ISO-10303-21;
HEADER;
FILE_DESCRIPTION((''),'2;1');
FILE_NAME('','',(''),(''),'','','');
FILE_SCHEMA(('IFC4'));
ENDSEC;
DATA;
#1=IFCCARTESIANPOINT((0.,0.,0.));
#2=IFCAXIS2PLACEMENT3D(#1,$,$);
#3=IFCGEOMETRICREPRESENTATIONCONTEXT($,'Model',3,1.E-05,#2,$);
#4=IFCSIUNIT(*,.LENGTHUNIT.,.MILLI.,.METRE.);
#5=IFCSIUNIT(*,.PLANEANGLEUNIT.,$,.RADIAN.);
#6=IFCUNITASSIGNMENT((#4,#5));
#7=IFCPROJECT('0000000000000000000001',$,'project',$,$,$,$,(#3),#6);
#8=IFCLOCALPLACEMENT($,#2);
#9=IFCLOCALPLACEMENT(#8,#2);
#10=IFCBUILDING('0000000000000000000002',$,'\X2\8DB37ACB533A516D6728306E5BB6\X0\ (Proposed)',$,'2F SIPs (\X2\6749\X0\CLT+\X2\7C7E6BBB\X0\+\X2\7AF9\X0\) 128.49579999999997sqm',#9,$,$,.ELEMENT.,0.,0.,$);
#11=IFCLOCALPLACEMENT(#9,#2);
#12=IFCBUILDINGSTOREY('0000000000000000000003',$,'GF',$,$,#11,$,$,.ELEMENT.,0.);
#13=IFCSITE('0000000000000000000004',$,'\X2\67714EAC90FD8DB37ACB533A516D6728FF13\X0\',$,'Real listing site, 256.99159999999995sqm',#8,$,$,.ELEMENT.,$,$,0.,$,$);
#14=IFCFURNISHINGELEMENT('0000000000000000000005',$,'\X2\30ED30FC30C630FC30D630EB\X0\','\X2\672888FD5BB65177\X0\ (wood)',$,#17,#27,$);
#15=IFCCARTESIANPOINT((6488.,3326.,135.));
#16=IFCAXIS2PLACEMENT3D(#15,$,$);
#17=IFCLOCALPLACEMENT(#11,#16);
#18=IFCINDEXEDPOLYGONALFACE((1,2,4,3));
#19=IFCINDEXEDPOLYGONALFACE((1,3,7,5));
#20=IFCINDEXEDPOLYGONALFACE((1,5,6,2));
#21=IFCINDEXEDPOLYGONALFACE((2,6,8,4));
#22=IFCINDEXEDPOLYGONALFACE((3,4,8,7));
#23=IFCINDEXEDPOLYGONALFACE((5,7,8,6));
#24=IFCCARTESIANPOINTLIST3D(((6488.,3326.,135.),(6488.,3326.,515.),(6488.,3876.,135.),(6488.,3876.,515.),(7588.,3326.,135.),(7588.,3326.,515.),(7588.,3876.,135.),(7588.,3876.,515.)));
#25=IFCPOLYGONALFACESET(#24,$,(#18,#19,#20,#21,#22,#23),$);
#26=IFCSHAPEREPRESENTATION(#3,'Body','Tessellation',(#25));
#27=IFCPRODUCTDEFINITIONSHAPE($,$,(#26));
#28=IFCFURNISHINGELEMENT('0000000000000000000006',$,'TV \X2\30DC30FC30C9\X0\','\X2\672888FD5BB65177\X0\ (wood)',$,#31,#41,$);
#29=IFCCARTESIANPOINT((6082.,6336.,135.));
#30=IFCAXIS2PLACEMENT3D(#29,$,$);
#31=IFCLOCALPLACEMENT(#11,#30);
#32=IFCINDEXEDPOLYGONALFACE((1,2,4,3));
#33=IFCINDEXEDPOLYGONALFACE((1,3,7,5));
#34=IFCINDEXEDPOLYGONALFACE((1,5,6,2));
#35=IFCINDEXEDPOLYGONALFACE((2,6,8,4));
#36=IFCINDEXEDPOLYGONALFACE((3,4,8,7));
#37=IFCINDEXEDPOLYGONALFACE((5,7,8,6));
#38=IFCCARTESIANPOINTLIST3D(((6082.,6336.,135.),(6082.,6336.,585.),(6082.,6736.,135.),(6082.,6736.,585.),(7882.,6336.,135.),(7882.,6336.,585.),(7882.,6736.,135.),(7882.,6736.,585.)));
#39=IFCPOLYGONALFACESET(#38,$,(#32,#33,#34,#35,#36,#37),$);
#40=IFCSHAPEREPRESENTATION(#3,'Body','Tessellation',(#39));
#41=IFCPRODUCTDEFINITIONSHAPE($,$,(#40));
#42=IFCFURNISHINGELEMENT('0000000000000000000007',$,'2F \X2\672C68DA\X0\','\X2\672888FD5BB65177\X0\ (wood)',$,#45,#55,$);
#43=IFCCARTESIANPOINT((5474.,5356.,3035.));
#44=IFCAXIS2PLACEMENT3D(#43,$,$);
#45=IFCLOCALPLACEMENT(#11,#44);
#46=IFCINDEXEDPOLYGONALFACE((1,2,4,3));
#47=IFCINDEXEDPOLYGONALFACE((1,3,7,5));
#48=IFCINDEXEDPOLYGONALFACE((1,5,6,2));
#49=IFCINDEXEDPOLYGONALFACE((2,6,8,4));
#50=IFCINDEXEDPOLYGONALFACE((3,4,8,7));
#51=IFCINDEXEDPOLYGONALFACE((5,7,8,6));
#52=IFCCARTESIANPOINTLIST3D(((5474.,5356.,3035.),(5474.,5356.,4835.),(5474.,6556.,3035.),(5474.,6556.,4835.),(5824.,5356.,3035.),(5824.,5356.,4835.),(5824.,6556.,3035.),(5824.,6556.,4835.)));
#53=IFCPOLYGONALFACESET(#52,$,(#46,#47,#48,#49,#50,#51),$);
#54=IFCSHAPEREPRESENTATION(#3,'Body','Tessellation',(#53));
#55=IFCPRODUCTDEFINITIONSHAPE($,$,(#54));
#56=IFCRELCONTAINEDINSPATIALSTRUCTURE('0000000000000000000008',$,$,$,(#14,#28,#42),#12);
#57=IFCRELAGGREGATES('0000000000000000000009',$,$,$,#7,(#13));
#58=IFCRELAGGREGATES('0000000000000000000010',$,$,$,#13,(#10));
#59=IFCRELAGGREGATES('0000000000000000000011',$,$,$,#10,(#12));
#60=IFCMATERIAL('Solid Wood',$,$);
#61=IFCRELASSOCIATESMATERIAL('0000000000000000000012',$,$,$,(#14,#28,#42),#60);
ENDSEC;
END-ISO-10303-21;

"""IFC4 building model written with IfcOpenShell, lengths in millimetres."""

from ifc_helpers import new_model, si_unit, frame, frame_2d, origin, place, context, project, spatial, rectangle, extrude, material, element, save


model = new_model("IFC4")

# Units and contexts
model_context = context("Model", 3, precision=1e-05, world=origin())
ifc_project = project(units=[si_unit("LENGTHUNIT", "METRE", prefix="MILLI"), si_unit("PLANEANGLEUNIT", "RADIAN")], contexts=[model_context])

# Site, building, storey
site_placement = place(None, origin())
site = spatial("IfcSite", under=ifc_project, at=site_placement, Name="東京都足立区六木３", ObjectType="Real listing site, 256.99159999999995sqm", CompositionType="ELEMENT", RefElevation=0.0)
building_placement = place(site_placement, origin())
building = spatial("IfcBuilding", under=site, at=building_placement, Name="足立区六木の家 (Proposed)", ObjectType="2F SIPs (杉CLT+籾殻+竹) 128.49579999999997sqm", CompositionType="ELEMENT", ElevationOfRefHeight=0.0, ElevationOfTerrain=0.0)
storey_placement = place(building_placement, origin())
storey = spatial("IfcBuildingStorey", under=building, at=storey_placement, Name="GF", CompositionType="ELEMENT", Elevation=0.0)

# Shared definitions
ifc_material_1 = material(Name="Solid Wood")

# Furnishing elements
furnishing_1_placement = place(storey_placement, frame((6488.0, 3326.0, 135.0)))
element("IfcFurnishingElement", 1, at=furnishing_1_placement, inside=storey, material=ifc_material_1, Name="ローテーブル", Description="木製家具 (wood)", context=model_context, shape_type="SweptSolid", body=[
    extrude(rectangle(XDim=1100.0, YDim=550.0, at=frame_2d((550.0, 275.0))), frame((6488.0, 3326.0, 135.0)), (0.0, 0.0, 1.0), 380.0),
])
furnishing_2_placement = place(storey_placement, frame((6082.0, 6336.0, 135.0)))
element("IfcFurnishingElement", 2, at=furnishing_2_placement, inside=storey, material=ifc_material_1, Name="TV ボード", Description="木製家具 (wood)", context=model_context, shape_type="SweptSolid", body=[
    extrude(rectangle(XDim=1800.0, YDim=400.0, at=frame_2d((900.0, 200.0))), frame((6082.0, 6336.0, 135.0)), (0.0, 0.0, 1.0), 450.0),
])
furnishing_3_placement = place(storey_placement, frame((5474.0, 5356.0, 3035.0)))
element("IfcFurnishingElement", 3, at=furnishing_3_placement, inside=storey, material=ifc_material_1, Name="2F 本棚", Description="木製家具 (wood)", context=model_context, shape_type="SweptSolid", body=[
    extrude(rectangle(XDim=350.0, YDim=1200.0, at=frame_2d((175.0, 600.0))), frame((5474.0, 5356.0, 3035.0)), (0.0, 0.0, 1.0), 1800.0),
])

save(model, "model.ifc")
